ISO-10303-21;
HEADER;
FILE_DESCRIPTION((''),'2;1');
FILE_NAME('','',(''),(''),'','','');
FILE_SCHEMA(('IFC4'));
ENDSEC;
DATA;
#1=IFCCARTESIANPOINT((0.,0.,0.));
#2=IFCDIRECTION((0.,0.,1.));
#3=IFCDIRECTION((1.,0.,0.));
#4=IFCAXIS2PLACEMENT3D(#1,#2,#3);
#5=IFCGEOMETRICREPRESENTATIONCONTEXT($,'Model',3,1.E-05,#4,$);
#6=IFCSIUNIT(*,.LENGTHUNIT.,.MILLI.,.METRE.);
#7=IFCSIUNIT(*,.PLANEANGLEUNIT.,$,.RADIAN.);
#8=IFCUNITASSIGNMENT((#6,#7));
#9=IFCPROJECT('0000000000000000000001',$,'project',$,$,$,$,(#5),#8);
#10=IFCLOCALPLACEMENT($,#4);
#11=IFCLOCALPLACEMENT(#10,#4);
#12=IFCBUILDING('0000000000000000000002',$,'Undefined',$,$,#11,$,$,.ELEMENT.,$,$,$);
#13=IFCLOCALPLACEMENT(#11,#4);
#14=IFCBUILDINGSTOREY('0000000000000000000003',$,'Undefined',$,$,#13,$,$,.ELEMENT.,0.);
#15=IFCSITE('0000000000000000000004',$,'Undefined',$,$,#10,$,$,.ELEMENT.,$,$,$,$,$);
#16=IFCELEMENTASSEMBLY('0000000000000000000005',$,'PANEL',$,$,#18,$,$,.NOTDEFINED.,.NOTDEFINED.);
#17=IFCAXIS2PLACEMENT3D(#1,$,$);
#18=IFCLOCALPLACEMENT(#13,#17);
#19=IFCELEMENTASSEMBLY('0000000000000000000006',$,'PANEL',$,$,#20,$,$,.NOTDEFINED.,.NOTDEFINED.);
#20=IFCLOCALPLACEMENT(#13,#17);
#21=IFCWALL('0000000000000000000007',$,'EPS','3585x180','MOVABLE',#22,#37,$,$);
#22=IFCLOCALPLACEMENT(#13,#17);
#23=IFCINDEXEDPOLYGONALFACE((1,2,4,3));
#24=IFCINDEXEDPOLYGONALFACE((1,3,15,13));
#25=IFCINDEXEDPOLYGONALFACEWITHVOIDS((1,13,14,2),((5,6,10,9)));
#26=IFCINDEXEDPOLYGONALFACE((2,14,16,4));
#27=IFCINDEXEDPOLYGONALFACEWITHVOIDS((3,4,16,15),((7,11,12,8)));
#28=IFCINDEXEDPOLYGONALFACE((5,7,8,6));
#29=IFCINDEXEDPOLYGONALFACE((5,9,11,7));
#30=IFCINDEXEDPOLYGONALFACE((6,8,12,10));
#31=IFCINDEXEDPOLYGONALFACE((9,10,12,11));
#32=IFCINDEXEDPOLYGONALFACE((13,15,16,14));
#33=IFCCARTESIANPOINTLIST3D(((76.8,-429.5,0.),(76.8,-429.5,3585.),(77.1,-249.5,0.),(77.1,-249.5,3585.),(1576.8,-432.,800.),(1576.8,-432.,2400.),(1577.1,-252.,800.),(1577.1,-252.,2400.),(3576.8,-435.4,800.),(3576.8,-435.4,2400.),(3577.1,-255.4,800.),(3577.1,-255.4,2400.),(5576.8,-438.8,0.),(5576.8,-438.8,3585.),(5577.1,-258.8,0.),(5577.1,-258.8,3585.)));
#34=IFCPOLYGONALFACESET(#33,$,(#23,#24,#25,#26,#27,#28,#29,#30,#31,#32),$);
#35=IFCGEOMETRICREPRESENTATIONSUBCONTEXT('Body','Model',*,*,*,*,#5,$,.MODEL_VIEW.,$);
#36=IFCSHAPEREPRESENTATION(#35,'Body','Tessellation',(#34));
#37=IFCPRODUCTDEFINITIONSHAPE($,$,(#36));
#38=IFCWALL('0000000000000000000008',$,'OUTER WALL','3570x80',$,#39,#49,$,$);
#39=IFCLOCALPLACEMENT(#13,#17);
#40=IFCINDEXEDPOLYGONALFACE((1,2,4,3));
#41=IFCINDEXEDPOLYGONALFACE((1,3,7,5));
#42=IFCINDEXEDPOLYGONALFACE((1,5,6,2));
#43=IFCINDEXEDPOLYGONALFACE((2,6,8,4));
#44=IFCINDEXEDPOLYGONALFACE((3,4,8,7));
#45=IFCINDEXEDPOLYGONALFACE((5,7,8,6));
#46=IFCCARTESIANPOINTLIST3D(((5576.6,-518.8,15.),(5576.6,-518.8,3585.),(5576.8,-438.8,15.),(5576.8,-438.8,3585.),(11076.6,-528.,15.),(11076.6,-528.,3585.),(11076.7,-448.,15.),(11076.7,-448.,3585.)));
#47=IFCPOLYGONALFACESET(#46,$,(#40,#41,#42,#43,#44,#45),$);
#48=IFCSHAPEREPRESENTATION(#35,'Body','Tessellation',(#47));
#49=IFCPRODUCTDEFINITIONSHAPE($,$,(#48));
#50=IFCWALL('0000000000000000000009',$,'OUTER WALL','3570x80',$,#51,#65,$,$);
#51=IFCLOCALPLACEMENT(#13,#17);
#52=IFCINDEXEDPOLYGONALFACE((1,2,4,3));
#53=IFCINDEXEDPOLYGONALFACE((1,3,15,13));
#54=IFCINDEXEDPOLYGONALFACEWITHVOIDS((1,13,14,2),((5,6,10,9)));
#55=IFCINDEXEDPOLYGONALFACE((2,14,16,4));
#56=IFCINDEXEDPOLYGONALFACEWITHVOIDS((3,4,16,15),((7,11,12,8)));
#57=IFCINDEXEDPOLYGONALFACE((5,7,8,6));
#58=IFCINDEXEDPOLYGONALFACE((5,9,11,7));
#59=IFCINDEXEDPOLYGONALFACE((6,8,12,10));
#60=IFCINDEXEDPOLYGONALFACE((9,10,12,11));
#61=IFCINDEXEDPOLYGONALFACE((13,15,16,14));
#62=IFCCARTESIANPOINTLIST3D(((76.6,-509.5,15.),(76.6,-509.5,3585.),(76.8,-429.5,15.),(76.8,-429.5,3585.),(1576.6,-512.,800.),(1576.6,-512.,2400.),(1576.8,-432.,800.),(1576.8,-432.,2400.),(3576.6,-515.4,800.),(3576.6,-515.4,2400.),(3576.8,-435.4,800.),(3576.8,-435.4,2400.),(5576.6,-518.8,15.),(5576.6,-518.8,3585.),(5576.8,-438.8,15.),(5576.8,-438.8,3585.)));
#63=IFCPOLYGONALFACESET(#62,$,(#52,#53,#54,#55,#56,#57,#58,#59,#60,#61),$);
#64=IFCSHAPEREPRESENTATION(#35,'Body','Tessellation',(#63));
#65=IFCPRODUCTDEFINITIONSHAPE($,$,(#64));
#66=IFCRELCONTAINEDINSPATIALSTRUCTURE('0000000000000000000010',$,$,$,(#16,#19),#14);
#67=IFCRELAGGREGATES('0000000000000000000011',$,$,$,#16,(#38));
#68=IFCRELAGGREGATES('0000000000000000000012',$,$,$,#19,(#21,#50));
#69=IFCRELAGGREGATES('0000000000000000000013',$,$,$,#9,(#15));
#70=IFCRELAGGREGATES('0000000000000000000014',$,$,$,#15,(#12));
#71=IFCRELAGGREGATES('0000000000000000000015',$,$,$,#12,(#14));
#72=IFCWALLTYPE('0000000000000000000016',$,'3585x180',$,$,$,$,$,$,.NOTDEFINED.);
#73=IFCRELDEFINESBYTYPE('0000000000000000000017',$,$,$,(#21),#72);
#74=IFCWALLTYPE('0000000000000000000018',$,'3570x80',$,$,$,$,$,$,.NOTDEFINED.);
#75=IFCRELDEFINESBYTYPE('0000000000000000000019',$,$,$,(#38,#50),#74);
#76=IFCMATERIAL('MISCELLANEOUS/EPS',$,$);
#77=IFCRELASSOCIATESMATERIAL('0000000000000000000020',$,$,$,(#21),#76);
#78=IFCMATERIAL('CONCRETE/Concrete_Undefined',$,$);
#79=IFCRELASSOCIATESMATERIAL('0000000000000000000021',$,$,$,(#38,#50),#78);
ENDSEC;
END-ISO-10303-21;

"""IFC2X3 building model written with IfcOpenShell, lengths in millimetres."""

from ifc_helpers import new_model, si_unit, frame, frame_2d, origin_with_axes, place, context, subcontext, project, spatial, polyline, rectangle, outline, extrude, material, type_object, element, aggregate, save


model = new_model("IFC2X3")

# Units and contexts
model_context = context("Model", 3, precision=1e-05, world=origin_with_axes())
body_context = subcontext(model_context, "Body", "Model", "MODEL_VIEW")
ifc_project = project(units=[si_unit("LENGTHUNIT", "METRE", prefix="MILLI"), si_unit("PLANEANGLEUNIT", "RADIAN")], contexts=[model_context])

# Site, building, storey
site_placement = place(None, origin_with_axes())
site = spatial("IfcSite", under=ifc_project, at=site_placement, Name="Undefined", CompositionType="ELEMENT")
building_placement = place(site_placement, origin_with_axes())
building = spatial("IfcBuilding", under=site, at=building_placement, Name="Undefined", CompositionType="ELEMENT")
storey_placement = place(building_placement, origin_with_axes())
storey = spatial("IfcBuildingStorey", under=building, at=storey_placement, Name="Undefined", CompositionType="ELEMENT", Elevation=0.0)

# Shared definitions
ifc_material_1 = material(Name="CONCRETE/Concrete_Undefined")

# Element assembly
assembly_1_placement = place(storey_placement, origin_with_axes())
assembly_1 = element("IfcElementAssembly", 1, at=assembly_1_placement, inside=storey, Name="PANEL", AssemblyPlace="NOTDEFINED", PredefinedType="NOTDEFINED")

# Element assembly
assembly_2_placement = place(storey_placement, origin_with_axes())
assembly_2 = element("IfcElementAssembly", 2, at=assembly_2_placement, inside=storey, Name="PANEL", AssemblyPlace="NOTDEFINED", PredefinedType="NOTDEFINED")

# Shared definitions
ifc_material_2 = material(Name="MISCELLANEOUS/EPS")
wall_type_1 = type_object("IfcWallType", Name="3585x180", PredefinedType="NOTDEFINED")

# Wall, opening
wall_1_placement = place(assembly_2_placement, frame((76.9, -339.5, 0.0), z_axis=(0.0, 0.0, 1.0), x_axis=(0.999999, -0.001684, 0.0)))
wall_1 = element("IfcWall", 3, at=wall_1_placement, type_object=wall_type_1, material=ifc_material_2, Name="EPS", Description="3585x180", ObjectType="MOVABLE", context=body_context, shape_type="SweptSolid", body=[
    extrude(rectangle(XDim=5500.0, YDim=180.0, at=frame_2d((0.0, 2750.0), x_axis=(0.0, -1.0))), frame((0.0, 0.0, 0.0), z_axis=(0.0, 0.0, 1.0), x_axis=(0.0, -1.0, 0.0)), (0.0, 0.0, 1.0), 3585.0),
])
opening_1_placement = place(assembly_2_placement, frame((76.9, -339.5, 0.0), z_axis=(0.0, 0.0, 1.0), x_axis=(0.999999, -0.001684, 0.0)))
element("IfcOpeningElement", 4, at=opening_1_placement, cuts=wall_1, ObjectType="Recess", context=body_context, shape_type="SweptSolid", body=[
    extrude(outline(polyline([(0.0, 0.0), (2000.0, 0.0), (2000.0, 1600.0), (0.0, 1600.0), (0.0, 0.0)])), frame((1500.0, 140.0, 800.0), z_axis=(0.0, -1.0, 0.0), x_axis=(1.0, 0.0, 0.0)), (0.0, 0.0, 1.0), 280.0),
])

# Wall
wall_type_2 = type_object("IfcWallType", Name="3570x80", PredefinedType="NOTDEFINED")
wall_2_placement = place(assembly_1_placement, frame((5576.7, -478.8, 15.0), z_axis=(0.0, 0.0, 1.0), x_axis=(0.999999, -0.001684, 0.0)))
wall_2 = element("IfcWall", 5, at=wall_2_placement, type_object=wall_type_2, material=ifc_material_1, Name="OUTER WALL", Description="3570x80", context=body_context, shape_type="SweptSolid", body=[
    extrude(rectangle(XDim=5500.0, YDim=80.0, at=frame_2d((0.0, 2750.0), x_axis=(0.0, -1.0))), frame((0.0, 0.0, 0.0), z_axis=(0.0, 0.0, 1.0), x_axis=(0.0, -1.0, 0.0)), (0.0, 0.0, 1.0), 3570.0),
])
aggregate(assembly_1, [wall_2])

# Wall, opening
wall_3_placement = place(assembly_2_placement, frame((76.7, -469.5, 15.0), z_axis=(0.0, 0.0, 1.0), x_axis=(0.999999, -0.001684, 0.0)))
wall_3 = element("IfcWall", 6, at=wall_3_placement, type_object=wall_type_2, material=ifc_material_1, Name="OUTER WALL", Description="3570x80", context=body_context, shape_type="SweptSolid", body=[
    extrude(rectangle(XDim=5500.0, YDim=80.0, at=frame_2d((0.0, 2750.0), x_axis=(0.0, -1.0))), frame((0.0, 0.0, 0.0), z_axis=(0.0, 0.0, 1.0), x_axis=(0.0, -1.0, 0.0)), (0.0, 0.0, 1.0), 3570.0),
])
opening_2_placement = place(assembly_2_placement, frame((76.7, -469.5, 15.0), z_axis=(0.0, 0.0, 1.0), x_axis=(0.999999, -0.001684, 0.0)))
element("IfcOpeningElement", 7, at=opening_2_placement, cuts=wall_3, ObjectType="Recess", context=body_context, shape_type="SweptSolid", body=[
    extrude(outline(polyline([(0.0, 0.0), (2000.0, 0.0), (2000.0, 1600.0), (0.0, 1600.0), (0.0, 0.0)])), frame((1500.0, 90.0, 785.0), z_axis=(0.0, -1.0, 0.0), x_axis=(1.0, 0.0, 0.0)), (0.0, 0.0, 1.0), 180.0),
])
aggregate(assembly_2, [wall_1, wall_3])

save(model, "model.ifc")
